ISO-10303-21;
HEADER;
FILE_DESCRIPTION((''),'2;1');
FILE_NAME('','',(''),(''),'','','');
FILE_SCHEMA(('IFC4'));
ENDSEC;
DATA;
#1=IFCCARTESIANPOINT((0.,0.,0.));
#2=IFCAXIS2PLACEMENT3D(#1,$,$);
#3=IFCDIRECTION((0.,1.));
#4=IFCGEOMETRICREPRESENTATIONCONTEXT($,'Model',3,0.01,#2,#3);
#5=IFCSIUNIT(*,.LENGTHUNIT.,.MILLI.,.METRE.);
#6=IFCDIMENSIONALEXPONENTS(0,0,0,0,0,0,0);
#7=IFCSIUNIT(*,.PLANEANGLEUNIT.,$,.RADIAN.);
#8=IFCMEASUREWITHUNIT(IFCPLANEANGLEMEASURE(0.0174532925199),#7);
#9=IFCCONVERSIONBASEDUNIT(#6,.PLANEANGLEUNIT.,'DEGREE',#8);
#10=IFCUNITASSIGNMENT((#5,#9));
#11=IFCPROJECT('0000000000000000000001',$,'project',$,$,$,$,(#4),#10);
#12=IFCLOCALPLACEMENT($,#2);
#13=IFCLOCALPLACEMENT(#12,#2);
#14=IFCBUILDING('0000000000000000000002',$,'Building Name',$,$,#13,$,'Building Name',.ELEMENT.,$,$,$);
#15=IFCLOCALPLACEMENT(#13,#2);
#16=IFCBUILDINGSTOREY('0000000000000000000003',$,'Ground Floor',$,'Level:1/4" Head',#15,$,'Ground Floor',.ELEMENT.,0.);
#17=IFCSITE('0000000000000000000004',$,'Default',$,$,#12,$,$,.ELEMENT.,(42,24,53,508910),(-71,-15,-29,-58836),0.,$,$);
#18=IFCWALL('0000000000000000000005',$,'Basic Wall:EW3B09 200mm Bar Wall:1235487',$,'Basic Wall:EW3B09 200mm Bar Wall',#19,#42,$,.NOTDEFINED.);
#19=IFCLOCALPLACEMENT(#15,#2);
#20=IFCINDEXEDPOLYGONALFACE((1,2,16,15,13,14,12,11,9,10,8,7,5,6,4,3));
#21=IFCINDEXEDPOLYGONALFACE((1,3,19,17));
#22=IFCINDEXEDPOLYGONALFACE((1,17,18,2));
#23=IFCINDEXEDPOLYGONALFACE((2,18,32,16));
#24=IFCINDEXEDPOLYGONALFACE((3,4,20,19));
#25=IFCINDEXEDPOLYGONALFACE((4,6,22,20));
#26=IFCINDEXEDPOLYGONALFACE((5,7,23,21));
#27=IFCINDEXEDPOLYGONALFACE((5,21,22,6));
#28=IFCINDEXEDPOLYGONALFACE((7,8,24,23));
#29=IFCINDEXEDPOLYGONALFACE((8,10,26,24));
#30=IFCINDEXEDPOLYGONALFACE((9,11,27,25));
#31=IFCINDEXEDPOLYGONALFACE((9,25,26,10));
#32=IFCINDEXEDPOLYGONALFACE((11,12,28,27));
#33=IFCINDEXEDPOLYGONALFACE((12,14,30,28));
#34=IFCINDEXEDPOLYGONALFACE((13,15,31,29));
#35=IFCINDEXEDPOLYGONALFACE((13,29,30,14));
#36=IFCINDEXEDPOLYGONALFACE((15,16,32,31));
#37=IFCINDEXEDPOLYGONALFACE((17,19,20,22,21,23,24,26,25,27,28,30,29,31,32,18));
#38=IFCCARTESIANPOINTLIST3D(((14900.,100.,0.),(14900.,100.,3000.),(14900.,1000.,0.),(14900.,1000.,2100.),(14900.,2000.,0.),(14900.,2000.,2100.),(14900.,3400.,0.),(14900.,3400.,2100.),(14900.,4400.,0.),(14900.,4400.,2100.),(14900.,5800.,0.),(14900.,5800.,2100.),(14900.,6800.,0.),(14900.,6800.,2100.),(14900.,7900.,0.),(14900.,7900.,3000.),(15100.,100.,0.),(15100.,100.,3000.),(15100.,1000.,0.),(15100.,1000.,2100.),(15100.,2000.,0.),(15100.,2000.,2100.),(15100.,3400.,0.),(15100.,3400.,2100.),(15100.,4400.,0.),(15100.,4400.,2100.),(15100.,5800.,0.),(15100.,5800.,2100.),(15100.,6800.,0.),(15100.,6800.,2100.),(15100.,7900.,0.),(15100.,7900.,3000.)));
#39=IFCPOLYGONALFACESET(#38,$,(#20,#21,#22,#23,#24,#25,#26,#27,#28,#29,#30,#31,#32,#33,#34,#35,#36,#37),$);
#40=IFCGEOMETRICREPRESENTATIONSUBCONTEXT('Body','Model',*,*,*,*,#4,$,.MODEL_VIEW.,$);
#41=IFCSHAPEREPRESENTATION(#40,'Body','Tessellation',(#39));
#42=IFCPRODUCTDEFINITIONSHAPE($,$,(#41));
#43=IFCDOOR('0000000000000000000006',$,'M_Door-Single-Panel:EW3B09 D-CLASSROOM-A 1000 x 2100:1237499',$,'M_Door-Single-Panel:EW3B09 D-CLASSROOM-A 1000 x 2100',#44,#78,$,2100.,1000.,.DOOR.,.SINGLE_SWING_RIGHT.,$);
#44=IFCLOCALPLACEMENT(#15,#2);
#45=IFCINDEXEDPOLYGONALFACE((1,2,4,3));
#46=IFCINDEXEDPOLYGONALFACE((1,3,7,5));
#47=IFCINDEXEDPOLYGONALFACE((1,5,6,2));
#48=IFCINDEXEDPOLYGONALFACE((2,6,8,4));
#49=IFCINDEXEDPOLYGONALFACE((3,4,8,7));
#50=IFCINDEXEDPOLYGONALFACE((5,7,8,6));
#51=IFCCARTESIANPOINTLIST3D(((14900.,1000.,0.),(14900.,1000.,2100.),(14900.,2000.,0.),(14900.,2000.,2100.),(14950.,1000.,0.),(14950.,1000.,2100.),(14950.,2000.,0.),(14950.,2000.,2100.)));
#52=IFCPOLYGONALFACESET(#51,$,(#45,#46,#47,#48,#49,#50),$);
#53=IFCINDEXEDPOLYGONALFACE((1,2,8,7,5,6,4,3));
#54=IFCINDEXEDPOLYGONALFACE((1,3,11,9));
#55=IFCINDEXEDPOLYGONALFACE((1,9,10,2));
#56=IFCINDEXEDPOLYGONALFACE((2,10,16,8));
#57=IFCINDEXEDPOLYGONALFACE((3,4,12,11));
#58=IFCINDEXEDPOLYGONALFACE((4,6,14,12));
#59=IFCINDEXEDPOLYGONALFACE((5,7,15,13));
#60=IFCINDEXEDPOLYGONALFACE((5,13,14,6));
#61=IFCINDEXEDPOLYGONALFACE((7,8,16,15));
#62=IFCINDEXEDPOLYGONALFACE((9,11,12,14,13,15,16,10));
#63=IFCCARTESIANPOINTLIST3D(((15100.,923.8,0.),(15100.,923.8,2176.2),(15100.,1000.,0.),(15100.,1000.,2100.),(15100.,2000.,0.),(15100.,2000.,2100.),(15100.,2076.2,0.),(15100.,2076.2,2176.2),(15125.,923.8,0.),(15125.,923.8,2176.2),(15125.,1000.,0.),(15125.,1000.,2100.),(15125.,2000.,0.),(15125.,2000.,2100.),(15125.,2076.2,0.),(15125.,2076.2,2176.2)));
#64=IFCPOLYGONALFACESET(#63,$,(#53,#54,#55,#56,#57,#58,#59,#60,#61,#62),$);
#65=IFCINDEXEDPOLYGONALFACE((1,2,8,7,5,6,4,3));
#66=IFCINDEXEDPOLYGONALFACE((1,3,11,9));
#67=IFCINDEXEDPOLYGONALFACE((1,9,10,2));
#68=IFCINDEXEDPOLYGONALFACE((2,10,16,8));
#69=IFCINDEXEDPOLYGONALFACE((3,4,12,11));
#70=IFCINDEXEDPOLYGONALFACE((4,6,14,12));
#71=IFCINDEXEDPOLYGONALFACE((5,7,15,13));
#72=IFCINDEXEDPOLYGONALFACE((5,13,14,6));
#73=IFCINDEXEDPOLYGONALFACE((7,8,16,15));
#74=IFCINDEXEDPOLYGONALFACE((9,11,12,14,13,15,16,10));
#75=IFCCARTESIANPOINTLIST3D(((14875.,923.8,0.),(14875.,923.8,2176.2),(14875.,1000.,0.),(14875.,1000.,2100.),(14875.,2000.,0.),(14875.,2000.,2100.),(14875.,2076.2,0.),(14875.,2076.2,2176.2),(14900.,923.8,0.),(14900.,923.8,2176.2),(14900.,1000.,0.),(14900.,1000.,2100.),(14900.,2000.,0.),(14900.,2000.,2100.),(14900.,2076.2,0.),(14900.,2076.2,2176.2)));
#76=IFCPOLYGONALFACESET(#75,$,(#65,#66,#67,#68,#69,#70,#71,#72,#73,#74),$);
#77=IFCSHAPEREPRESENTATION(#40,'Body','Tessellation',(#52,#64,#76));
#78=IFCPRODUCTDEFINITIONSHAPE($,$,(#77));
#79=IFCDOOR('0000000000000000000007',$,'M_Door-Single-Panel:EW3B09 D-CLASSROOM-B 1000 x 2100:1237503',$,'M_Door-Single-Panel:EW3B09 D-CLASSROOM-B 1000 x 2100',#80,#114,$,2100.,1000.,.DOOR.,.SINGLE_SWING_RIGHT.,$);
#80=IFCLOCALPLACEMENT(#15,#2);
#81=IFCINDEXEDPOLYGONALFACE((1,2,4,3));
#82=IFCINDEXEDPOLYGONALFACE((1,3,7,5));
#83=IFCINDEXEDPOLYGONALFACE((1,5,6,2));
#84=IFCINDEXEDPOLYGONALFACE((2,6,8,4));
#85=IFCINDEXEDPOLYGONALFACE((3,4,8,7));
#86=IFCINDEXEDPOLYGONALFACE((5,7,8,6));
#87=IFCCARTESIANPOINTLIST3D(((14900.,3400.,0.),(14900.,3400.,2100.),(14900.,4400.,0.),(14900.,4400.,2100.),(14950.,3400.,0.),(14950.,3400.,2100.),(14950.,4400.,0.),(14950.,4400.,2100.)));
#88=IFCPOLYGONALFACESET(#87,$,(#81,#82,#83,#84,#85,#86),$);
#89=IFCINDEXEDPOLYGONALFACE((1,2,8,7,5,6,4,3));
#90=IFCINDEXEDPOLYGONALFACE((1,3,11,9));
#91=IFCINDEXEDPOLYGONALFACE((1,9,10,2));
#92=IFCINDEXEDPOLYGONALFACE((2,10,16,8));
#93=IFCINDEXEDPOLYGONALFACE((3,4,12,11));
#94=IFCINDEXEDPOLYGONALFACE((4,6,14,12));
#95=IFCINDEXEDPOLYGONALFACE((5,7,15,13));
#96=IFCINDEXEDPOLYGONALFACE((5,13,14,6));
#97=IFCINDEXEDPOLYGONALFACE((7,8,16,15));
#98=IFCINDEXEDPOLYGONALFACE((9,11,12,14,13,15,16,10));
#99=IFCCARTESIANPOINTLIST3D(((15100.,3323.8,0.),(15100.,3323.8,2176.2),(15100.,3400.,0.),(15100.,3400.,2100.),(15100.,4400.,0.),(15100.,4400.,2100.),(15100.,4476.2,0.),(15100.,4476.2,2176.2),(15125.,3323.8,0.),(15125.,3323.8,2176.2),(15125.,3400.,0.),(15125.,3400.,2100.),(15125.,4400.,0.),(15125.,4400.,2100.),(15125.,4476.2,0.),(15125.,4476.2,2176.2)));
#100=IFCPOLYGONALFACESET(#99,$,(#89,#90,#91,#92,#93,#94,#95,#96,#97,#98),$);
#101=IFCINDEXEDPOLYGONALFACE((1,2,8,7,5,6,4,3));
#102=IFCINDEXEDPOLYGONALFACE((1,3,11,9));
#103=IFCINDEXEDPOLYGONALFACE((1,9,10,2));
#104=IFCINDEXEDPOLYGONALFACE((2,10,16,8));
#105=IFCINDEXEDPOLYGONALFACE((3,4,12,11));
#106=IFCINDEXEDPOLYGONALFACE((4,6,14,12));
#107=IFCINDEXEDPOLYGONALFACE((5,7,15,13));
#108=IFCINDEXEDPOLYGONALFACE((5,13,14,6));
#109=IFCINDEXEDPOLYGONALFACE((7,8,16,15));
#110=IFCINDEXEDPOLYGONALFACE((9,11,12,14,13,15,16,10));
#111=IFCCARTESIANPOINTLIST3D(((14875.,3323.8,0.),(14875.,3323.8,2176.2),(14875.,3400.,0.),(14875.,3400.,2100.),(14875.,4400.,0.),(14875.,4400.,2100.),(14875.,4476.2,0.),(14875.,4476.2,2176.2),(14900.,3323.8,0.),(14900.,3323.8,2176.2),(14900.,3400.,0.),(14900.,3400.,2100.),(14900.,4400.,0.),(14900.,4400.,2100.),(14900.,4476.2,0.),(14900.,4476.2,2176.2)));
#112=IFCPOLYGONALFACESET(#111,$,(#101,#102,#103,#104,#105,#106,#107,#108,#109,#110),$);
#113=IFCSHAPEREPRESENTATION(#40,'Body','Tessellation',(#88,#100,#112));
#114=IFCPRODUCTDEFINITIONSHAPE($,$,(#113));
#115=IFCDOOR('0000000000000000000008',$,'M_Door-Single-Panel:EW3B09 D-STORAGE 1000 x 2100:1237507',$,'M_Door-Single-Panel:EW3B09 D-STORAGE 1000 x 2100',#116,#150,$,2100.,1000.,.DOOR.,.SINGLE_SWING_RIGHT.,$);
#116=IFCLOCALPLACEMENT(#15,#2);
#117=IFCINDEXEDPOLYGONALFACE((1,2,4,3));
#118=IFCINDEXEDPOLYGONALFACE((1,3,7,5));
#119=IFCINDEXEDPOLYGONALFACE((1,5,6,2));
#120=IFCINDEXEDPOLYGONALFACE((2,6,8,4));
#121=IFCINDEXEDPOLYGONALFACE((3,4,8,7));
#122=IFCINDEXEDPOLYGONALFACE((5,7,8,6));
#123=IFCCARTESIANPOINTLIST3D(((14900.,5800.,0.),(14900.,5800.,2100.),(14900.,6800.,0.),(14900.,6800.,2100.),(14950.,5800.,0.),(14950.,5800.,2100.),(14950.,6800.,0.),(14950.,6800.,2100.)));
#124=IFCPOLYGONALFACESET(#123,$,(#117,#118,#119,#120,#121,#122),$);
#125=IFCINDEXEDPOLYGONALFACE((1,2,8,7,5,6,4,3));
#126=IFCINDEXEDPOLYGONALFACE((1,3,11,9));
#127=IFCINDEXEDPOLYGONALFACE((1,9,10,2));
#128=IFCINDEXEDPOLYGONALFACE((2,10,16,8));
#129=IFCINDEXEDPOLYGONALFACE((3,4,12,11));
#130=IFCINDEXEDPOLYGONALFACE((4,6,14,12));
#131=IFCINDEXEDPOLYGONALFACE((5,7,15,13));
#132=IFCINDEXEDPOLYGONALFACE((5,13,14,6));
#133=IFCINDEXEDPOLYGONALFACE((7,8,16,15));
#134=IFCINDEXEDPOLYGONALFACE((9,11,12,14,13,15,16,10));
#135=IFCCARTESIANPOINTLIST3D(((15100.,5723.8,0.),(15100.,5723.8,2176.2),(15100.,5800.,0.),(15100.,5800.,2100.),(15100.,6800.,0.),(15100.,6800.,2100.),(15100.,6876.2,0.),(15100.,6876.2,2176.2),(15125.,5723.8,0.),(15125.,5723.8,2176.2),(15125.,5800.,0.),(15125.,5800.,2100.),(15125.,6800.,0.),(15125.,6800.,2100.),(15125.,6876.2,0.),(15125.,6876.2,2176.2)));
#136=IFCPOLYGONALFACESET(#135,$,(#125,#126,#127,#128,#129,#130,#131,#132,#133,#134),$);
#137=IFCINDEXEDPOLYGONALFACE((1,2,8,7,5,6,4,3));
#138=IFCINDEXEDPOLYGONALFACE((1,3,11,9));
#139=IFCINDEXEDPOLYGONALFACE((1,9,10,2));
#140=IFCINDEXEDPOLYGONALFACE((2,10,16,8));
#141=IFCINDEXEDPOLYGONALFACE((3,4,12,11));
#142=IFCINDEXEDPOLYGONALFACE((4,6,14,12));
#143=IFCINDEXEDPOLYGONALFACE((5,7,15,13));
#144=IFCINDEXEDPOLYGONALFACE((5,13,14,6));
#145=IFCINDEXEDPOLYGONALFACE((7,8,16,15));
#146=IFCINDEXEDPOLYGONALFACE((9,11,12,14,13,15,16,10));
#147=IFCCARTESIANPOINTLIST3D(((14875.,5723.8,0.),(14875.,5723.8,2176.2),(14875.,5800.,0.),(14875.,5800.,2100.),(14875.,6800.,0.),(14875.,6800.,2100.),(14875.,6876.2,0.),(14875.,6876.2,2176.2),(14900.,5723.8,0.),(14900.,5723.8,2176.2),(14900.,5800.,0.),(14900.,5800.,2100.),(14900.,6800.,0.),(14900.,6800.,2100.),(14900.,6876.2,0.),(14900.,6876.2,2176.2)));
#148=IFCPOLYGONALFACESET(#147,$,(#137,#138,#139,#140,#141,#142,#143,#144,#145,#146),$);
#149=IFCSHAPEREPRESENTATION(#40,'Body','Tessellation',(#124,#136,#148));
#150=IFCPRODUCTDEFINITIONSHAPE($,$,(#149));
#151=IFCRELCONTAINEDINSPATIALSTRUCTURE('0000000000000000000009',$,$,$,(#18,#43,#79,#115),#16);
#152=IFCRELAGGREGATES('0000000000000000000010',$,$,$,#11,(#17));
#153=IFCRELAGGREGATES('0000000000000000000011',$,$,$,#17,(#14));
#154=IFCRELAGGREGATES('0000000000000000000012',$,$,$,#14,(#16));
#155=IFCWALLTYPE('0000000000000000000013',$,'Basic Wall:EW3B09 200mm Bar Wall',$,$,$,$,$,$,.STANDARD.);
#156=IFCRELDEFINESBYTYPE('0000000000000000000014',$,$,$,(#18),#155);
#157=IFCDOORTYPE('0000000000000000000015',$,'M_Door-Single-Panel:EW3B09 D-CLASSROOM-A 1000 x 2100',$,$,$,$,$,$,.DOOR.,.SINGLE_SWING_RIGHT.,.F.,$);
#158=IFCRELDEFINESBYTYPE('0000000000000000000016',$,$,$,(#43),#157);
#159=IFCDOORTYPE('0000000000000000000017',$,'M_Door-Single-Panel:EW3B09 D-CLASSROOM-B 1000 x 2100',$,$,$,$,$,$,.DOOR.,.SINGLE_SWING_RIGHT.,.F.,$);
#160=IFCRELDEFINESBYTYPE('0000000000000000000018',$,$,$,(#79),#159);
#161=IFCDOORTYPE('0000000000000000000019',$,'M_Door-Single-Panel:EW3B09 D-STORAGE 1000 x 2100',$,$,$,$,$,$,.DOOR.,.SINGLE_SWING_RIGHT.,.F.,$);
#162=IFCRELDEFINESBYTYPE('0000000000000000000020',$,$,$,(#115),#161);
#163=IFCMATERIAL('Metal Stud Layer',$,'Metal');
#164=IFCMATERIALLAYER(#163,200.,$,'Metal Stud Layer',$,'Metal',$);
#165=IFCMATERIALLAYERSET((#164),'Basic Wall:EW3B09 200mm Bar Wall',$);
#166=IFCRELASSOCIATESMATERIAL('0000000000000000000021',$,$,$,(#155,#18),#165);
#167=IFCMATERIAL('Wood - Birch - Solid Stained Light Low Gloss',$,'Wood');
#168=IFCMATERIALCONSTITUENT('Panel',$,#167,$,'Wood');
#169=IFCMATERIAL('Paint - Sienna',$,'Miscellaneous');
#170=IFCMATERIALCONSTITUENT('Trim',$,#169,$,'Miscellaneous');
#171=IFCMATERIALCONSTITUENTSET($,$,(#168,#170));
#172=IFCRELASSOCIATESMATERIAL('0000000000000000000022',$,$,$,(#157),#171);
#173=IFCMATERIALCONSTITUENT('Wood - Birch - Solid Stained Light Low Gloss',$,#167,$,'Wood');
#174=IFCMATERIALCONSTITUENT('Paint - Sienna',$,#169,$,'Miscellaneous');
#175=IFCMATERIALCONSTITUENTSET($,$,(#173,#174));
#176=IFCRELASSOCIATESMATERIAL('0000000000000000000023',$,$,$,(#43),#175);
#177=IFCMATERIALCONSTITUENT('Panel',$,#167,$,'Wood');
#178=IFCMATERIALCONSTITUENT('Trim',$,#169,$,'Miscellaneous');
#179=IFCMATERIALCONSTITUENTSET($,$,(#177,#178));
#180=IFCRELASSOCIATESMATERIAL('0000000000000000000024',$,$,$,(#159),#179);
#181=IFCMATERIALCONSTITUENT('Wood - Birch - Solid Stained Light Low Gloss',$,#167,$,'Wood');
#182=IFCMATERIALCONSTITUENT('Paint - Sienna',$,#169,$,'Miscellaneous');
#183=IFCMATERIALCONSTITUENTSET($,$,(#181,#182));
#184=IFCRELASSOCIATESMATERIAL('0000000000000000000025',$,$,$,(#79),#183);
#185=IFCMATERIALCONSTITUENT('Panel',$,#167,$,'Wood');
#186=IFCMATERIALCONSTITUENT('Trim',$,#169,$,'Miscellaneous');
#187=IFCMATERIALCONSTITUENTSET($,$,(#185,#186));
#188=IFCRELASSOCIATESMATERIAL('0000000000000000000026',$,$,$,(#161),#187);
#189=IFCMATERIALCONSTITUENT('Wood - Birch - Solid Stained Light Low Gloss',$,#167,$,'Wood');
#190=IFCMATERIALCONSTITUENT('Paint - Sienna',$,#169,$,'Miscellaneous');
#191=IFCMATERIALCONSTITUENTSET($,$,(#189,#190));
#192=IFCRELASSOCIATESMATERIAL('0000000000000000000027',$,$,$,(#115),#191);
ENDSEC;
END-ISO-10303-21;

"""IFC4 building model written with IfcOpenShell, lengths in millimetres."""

from ifc_helpers import new_model, entity, si_unit, converted_unit, direction, frame, frame_2d, origin, place, context, subcontext, project, spatial, polyline, rectangle, outline, extrude, source, transform, mapped, material, layer, layer_set, layer_usage, constituent, constituent_set, type_object, type_shapes, element, fill, save


model = new_model("IFC4")

# Units and contexts
model_context = context("Model", 3, precision=0.01, world=origin(), true_north=direction((0.0, 1.0)))
body_context = subcontext(model_context, "Body", "Model", "MODEL_VIEW")
ifc_project = project(units=[si_unit("LENGTHUNIT", "METRE", prefix="MILLI"), converted_unit("PLANEANGLEUNIT", "DEGREE", entity("IfcPlaneAngleMeasure", 0.0174532925199), si_unit("PLANEANGLEUNIT", "RADIAN"), dimensions=[0, 0, 0, 0, 0, 0, 0])], contexts=[model_context])

# Site, building, storey
site_placement = place(None, origin())
site = spatial("IfcSite", under=ifc_project, at=site_placement, Name="Default", CompositionType="ELEMENT", RefLatitude=(42, 24, 53, 508910), RefLongitude=(-71, -15, -29, -58836), RefElevation=0.0)
building_placement = place(site_placement, origin())
building = spatial("IfcBuilding", under=site, at=building_placement, Name="Building Name", LongName="Building Name", CompositionType="ELEMENT")
storey_placement = place(building_placement, origin())
storey = spatial("IfcBuildingStorey", under=building, at=storey_placement, Name="Ground Floor", ObjectType="Level:1/4\" Head", LongName="Ground Floor", CompositionType="ELEMENT", Elevation=0.0)

# Shared definitions
ifc_material_1 = material(Name="Metal Stud Layer", Category="Metal")
ifc_layer_1 = layer(ifc_material_1, 200.0, Name="Metal Stud Layer", Category="Metal")
ifc_layer_set_1 = layer_set([ifc_layer_1], Name="Basic Wall:EW3B09 200mm Bar Wall")
wall_type = type_object("IfcWallType", Name="Basic Wall:EW3B09 200mm Bar Wall", PredefinedType="STANDARD", material=ifc_layer_set_1)
ifc_material_2 = material(Name="Wood - Birch - Solid Stained Light Low Gloss", Category="Wood")
ifc_material_3 = material(Name="Paint - Sienna", Category="Miscellaneous")

# Wall, openings, doors
ifc_layer_usage_1 = layer_usage(ifc_layer_set_1, "AXIS2", "NEGATIVE", 100.0)
wall_1_placement = place(storey_placement, frame((15000.0, 100.0, 0.0), z_axis=(0.0, 0.0, 1.0), x_axis=(0.0, 1.0, 0.0)))
wall_1 = element("IfcWall", 1, at=wall_1_placement, inside=storey, type_object=wall_type, material=ifc_layer_usage_1, Name="Basic Wall:EW3B09 200mm Bar Wall:1235487", ObjectType="Basic Wall:EW3B09 200mm Bar Wall", PredefinedType="NOTDEFINED", context=body_context, shape_type="SweptSolid", body=[
    extrude(rectangle(XDim=7800.0, YDim=200.0, at=frame_2d((3900.0, 0.0), x_axis=(1.0, 0.0))), origin(), (0.0, 0.0, 1.0), 3000.0),
])
opening_1_placement = place(wall_1_placement, frame((900.0, -100.0, 0.0)))
opening_1 = element("IfcOpeningElement", 2, at=opening_1_placement, cuts=wall_1, PredefinedType="OPENING", context=body_context, shape_type="SweptSolid", body=[
    extrude(rectangle(XDim=1000.0, YDim=2100.0, at=frame_2d((1050.0, 500.0), x_axis=(0.0, 1.0))), frame((0.0, 0.0, 0.0), z_axis=(0.0, 1.0, 0.0), x_axis=(0.0, 0.0, 1.0)), (0.0, 0.0, 1.0), 200.0),
])
opening_2_placement = place(wall_1_placement, frame((3300.0, -100.0, 0.0)))
opening_2 = element("IfcOpeningElement", 3, at=opening_2_placement, cuts=wall_1, PredefinedType="OPENING", context=body_context, shape_type="SweptSolid", body=[
    extrude(rectangle(XDim=1000.0, YDim=2100.0, at=frame_2d((1050.0, 500.0), x_axis=(0.0, 1.0))), frame((0.0, 0.0, 0.0), z_axis=(0.0, 1.0, 0.0), x_axis=(0.0, 0.0, 1.0)), (0.0, 0.0, 1.0), 200.0),
])
opening_3_placement = place(wall_1_placement, frame((5700.0, -100.0, 0.0)))
opening_3 = element("IfcOpeningElement", 4, at=opening_3_placement, cuts=wall_1, PredefinedType="OPENING", context=body_context, shape_type="SweptSolid", body=[
    extrude(rectangle(XDim=1000.0, YDim=2100.0, at=frame_2d((1050.0, 500.0), x_axis=(0.0, 1.0))), frame((0.0, 0.0, 0.0), z_axis=(0.0, 1.0, 0.0), x_axis=(0.0, 0.0, 1.0)), (0.0, 0.0, 1.0), 200.0),
])
ifc_constituent_1 = constituent(ifc_material_2, Name="Wood - Birch - Solid Stained Light Low Gloss", Category="Wood")
ifc_constituent_2 = constituent(ifc_material_3, Name="Paint - Sienna", Category="Miscellaneous")
ifc_constituent_set_1 = constituent_set(constituents=[ifc_constituent_1, ifc_constituent_2])
ifc_constituent_3 = constituent(ifc_material_2, Name="Panel", Category="Wood")
ifc_constituent_4 = constituent(ifc_material_3, Name="Trim", Category="Miscellaneous")
ifc_constituent_set_2 = constituent_set(constituents=[ifc_constituent_3, ifc_constituent_4])
door_type_1 = type_object("IfcDoorType", Name="M_Door-Single-Panel:EW3B09 D-CLASSROOM-A 1000 x 2100", OperationType="SINGLE_SWING_RIGHT", ParameterTakesPrecedence=False, PredefinedType="DOOR", material=ifc_constituent_set_2)
shared_shape_1 = source(origin(), body_context, "Body", "SweptSolid", [
    extrude(rectangle(XDim=50.0, YDim=1000.0, at=frame_2d((0.0, 0.0), x_axis=(1.0, 0.0))), frame((500.0, 175.0, 0.0), z_axis=(0.0, 0.0, 1.0), x_axis=(0.0, 1.0, 0.0)), (0.0, 0.0, 1.0), 2100.0),
    extrude(outline(polyline([(-1107.2, -576.2), (1069.0, -576.2), (1069.0, -500.0), (-1031.0, -500.0), (-1031.0, 500.0), (1069.0, 500.0), (1069.0, 576.2), (-1107.2, 576.2), (-1107.2, -576.2)])), frame((500.0, -25.0, 1069.0), z_axis=(0.0, 1.0, 0.0), x_axis=(0.0, 0.0, -1.0)), (0.0, 0.0, 1.0), 25.0),
    extrude(outline(polyline([(-576.2, -1107.2), (576.2, -1107.2), (576.2, 1069.0), (500.0, 1069.0), (500.0, -1031.0), (-500.0, -1031.0), (-500.0, 1069.0), (-576.2, 1069.0), (-576.2, -1107.2)])), frame((500.0, 200.0, 1069.0), z_axis=(0.0, 1.0, 0.0), x_axis=(1.0, 0.0, 0.0)), (0.0, 0.0, 1.0), 25.0),
])
type_shapes(door_type_1, [shared_shape_1])
door_1_placement = place(opening_1_placement, origin())
door_1 = element("IfcDoor", 5, at=door_1_placement, inside=storey, type_object=door_type_1, material=ifc_constituent_set_1, Name="M_Door-Single-Panel:EW3B09 D-CLASSROOM-A 1000 x 2100:1237499", ObjectType="M_Door-Single-Panel:EW3B09 D-CLASSROOM-A 1000 x 2100", OperationType="SINGLE_SWING_RIGHT", OverallHeight=2100.0, OverallWidth=1000.0, PredefinedType="DOOR", context=body_context, shape_type="MappedRepresentation", body=[
    mapped(shared_shape_1, transform((0.0, 0.0, 0.0), scale=1.0)),
])
fill(opening_1, door_1)
ifc_constituent_5 = constituent(ifc_material_2, Name="Wood - Birch - Solid Stained Light Low Gloss", Category="Wood")
ifc_constituent_6 = constituent(ifc_material_3, Name="Paint - Sienna", Category="Miscellaneous")
ifc_constituent_set_3 = constituent_set(constituents=[ifc_constituent_5, ifc_constituent_6])
ifc_constituent_7 = constituent(ifc_material_2, Name="Panel", Category="Wood")
ifc_constituent_8 = constituent(ifc_material_3, Name="Trim", Category="Miscellaneous")
ifc_constituent_set_4 = constituent_set(constituents=[ifc_constituent_7, ifc_constituent_8])
door_type_2 = type_object("IfcDoorType", Name="M_Door-Single-Panel:EW3B09 D-CLASSROOM-B 1000 x 2100", OperationType="SINGLE_SWING_RIGHT", ParameterTakesPrecedence=False, PredefinedType="DOOR", material=ifc_constituent_set_4)
shared_shape_2 = source(origin(), body_context, "Body", "SweptSolid", [
    extrude(rectangle(XDim=50.0, YDim=1000.0, at=frame_2d((0.0, 0.0), x_axis=(1.0, 0.0))), frame((500.0, 175.0, 0.0), z_axis=(0.0, 0.0, 1.0), x_axis=(0.0, 1.0, 0.0)), (0.0, 0.0, 1.0), 2100.0),
    extrude(outline(polyline([(-1107.2, -576.2), (1069.0, -576.2), (1069.0, -500.0), (-1031.0, -500.0), (-1031.0, 500.0), (1069.0, 500.0), (1069.0, 576.2), (-1107.2, 576.2), (-1107.2, -576.2)])), frame((500.0, -25.0, 1069.0), z_axis=(0.0, 1.0, 0.0), x_axis=(0.0, 0.0, -1.0)), (0.0, 0.0, 1.0), 25.0),
    extrude(outline(polyline([(-576.2, -1107.2), (576.2, -1107.2), (576.2, 1069.0), (500.0, 1069.0), (500.0, -1031.0), (-500.0, -1031.0), (-500.0, 1069.0), (-576.2, 1069.0), (-576.2, -1107.2)])), frame((500.0, 200.0, 1069.0), z_axis=(0.0, 1.0, 0.0), x_axis=(1.0, 0.0, 0.0)), (0.0, 0.0, 1.0), 25.0),
])
type_shapes(door_type_2, [shared_shape_2])
door_2_placement = place(opening_2_placement, origin())
door_2 = element("IfcDoor", 6, at=door_2_placement, inside=storey, type_object=door_type_2, material=ifc_constituent_set_3, Name="M_Door-Single-Panel:EW3B09 D-CLASSROOM-B 1000 x 2100:1237503", ObjectType="M_Door-Single-Panel:EW3B09 D-CLASSROOM-B 1000 x 2100", OperationType="SINGLE_SWING_RIGHT", OverallHeight=2100.0, OverallWidth=1000.0, PredefinedType="DOOR", context=body_context, shape_type="MappedRepresentation", body=[
    mapped(shared_shape_2, transform((0.0, 0.0, 0.0), scale=1.0)),
])
fill(opening_2, door_2)
ifc_constituent_9 = constituent(ifc_material_2, Name="Wood - Birch - Solid Stained Light Low Gloss", Category="Wood")
ifc_constituent_10 = constituent(ifc_material_3, Name="Paint - Sienna", Category="Miscellaneous")
ifc_constituent_set_5 = constituent_set(constituents=[ifc_constituent_9, ifc_constituent_10])
ifc_constituent_11 = constituent(ifc_material_2, Name="Panel", Category="Wood")
ifc_constituent_12 = constituent(ifc_material_3, Name="Trim", Category="Miscellaneous")
ifc_constituent_set_6 = constituent_set(constituents=[ifc_constituent_11, ifc_constituent_12])
door_type_3 = type_object("IfcDoorType", Name="M_Door-Single-Panel:EW3B09 D-STORAGE 1000 x 2100", OperationType="SINGLE_SWING_RIGHT", ParameterTakesPrecedence=False, PredefinedType="DOOR", material=ifc_constituent_set_6)
shared_shape_3 = source(origin(), body_context, "Body", "SweptSolid", [
    extrude(rectangle(XDim=50.0, YDim=1000.0, at=frame_2d((0.0, 0.0), x_axis=(1.0, 0.0))), frame((500.0, 175.0, 0.0), z_axis=(0.0, 0.0, 1.0), x_axis=(0.0, 1.0, 0.0)), (0.0, 0.0, 1.0), 2100.0),
    extrude(outline(polyline([(-1107.2, -576.2), (1069.0, -576.2), (1069.0, -500.0), (-1031.0, -500.0), (-1031.0, 500.0), (1069.0, 500.0), (1069.0, 576.2), (-1107.2, 576.2), (-1107.2, -576.2)])), frame((500.0, -25.0, 1069.0), z_axis=(0.0, 1.0, 0.0), x_axis=(0.0, 0.0, -1.0)), (0.0, 0.0, 1.0), 25.0),
    extrude(outline(polyline([(-576.2, -1107.2), (576.2, -1107.2), (576.2, 1069.0), (500.0, 1069.0), (500.0, -1031.0), (-500.0, -1031.0), (-500.0, 1069.0), (-576.2, 1069.0), (-576.2, -1107.2)])), frame((500.0, 200.0, 1069.0), z_axis=(0.0, 1.0, 0.0), x_axis=(1.0, 0.0, 0.0)), (0.0, 0.0, 1.0), 25.0),
])
type_shapes(door_type_3, [shared_shape_3])
door_3_placement = place(opening_3_placement, origin())
door_3 = element("IfcDoor", 7, at=door_3_placement, inside=storey, type_object=door_type_3, material=ifc_constituent_set_5, Name="M_Door-Single-Panel:EW3B09 D-STORAGE 1000 x 2100:1237507", ObjectType="M_Door-Single-Panel:EW3B09 D-STORAGE 1000 x 2100", OperationType="SINGLE_SWING_RIGHT", OverallHeight=2100.0, OverallWidth=1000.0, PredefinedType="DOOR", context=body_context, shape_type="MappedRepresentation", body=[
    mapped(shared_shape_3, transform((0.0, 0.0, 0.0), scale=1.0)),
])
fill(opening_3, door_3)

save(model, "model.ifc")
